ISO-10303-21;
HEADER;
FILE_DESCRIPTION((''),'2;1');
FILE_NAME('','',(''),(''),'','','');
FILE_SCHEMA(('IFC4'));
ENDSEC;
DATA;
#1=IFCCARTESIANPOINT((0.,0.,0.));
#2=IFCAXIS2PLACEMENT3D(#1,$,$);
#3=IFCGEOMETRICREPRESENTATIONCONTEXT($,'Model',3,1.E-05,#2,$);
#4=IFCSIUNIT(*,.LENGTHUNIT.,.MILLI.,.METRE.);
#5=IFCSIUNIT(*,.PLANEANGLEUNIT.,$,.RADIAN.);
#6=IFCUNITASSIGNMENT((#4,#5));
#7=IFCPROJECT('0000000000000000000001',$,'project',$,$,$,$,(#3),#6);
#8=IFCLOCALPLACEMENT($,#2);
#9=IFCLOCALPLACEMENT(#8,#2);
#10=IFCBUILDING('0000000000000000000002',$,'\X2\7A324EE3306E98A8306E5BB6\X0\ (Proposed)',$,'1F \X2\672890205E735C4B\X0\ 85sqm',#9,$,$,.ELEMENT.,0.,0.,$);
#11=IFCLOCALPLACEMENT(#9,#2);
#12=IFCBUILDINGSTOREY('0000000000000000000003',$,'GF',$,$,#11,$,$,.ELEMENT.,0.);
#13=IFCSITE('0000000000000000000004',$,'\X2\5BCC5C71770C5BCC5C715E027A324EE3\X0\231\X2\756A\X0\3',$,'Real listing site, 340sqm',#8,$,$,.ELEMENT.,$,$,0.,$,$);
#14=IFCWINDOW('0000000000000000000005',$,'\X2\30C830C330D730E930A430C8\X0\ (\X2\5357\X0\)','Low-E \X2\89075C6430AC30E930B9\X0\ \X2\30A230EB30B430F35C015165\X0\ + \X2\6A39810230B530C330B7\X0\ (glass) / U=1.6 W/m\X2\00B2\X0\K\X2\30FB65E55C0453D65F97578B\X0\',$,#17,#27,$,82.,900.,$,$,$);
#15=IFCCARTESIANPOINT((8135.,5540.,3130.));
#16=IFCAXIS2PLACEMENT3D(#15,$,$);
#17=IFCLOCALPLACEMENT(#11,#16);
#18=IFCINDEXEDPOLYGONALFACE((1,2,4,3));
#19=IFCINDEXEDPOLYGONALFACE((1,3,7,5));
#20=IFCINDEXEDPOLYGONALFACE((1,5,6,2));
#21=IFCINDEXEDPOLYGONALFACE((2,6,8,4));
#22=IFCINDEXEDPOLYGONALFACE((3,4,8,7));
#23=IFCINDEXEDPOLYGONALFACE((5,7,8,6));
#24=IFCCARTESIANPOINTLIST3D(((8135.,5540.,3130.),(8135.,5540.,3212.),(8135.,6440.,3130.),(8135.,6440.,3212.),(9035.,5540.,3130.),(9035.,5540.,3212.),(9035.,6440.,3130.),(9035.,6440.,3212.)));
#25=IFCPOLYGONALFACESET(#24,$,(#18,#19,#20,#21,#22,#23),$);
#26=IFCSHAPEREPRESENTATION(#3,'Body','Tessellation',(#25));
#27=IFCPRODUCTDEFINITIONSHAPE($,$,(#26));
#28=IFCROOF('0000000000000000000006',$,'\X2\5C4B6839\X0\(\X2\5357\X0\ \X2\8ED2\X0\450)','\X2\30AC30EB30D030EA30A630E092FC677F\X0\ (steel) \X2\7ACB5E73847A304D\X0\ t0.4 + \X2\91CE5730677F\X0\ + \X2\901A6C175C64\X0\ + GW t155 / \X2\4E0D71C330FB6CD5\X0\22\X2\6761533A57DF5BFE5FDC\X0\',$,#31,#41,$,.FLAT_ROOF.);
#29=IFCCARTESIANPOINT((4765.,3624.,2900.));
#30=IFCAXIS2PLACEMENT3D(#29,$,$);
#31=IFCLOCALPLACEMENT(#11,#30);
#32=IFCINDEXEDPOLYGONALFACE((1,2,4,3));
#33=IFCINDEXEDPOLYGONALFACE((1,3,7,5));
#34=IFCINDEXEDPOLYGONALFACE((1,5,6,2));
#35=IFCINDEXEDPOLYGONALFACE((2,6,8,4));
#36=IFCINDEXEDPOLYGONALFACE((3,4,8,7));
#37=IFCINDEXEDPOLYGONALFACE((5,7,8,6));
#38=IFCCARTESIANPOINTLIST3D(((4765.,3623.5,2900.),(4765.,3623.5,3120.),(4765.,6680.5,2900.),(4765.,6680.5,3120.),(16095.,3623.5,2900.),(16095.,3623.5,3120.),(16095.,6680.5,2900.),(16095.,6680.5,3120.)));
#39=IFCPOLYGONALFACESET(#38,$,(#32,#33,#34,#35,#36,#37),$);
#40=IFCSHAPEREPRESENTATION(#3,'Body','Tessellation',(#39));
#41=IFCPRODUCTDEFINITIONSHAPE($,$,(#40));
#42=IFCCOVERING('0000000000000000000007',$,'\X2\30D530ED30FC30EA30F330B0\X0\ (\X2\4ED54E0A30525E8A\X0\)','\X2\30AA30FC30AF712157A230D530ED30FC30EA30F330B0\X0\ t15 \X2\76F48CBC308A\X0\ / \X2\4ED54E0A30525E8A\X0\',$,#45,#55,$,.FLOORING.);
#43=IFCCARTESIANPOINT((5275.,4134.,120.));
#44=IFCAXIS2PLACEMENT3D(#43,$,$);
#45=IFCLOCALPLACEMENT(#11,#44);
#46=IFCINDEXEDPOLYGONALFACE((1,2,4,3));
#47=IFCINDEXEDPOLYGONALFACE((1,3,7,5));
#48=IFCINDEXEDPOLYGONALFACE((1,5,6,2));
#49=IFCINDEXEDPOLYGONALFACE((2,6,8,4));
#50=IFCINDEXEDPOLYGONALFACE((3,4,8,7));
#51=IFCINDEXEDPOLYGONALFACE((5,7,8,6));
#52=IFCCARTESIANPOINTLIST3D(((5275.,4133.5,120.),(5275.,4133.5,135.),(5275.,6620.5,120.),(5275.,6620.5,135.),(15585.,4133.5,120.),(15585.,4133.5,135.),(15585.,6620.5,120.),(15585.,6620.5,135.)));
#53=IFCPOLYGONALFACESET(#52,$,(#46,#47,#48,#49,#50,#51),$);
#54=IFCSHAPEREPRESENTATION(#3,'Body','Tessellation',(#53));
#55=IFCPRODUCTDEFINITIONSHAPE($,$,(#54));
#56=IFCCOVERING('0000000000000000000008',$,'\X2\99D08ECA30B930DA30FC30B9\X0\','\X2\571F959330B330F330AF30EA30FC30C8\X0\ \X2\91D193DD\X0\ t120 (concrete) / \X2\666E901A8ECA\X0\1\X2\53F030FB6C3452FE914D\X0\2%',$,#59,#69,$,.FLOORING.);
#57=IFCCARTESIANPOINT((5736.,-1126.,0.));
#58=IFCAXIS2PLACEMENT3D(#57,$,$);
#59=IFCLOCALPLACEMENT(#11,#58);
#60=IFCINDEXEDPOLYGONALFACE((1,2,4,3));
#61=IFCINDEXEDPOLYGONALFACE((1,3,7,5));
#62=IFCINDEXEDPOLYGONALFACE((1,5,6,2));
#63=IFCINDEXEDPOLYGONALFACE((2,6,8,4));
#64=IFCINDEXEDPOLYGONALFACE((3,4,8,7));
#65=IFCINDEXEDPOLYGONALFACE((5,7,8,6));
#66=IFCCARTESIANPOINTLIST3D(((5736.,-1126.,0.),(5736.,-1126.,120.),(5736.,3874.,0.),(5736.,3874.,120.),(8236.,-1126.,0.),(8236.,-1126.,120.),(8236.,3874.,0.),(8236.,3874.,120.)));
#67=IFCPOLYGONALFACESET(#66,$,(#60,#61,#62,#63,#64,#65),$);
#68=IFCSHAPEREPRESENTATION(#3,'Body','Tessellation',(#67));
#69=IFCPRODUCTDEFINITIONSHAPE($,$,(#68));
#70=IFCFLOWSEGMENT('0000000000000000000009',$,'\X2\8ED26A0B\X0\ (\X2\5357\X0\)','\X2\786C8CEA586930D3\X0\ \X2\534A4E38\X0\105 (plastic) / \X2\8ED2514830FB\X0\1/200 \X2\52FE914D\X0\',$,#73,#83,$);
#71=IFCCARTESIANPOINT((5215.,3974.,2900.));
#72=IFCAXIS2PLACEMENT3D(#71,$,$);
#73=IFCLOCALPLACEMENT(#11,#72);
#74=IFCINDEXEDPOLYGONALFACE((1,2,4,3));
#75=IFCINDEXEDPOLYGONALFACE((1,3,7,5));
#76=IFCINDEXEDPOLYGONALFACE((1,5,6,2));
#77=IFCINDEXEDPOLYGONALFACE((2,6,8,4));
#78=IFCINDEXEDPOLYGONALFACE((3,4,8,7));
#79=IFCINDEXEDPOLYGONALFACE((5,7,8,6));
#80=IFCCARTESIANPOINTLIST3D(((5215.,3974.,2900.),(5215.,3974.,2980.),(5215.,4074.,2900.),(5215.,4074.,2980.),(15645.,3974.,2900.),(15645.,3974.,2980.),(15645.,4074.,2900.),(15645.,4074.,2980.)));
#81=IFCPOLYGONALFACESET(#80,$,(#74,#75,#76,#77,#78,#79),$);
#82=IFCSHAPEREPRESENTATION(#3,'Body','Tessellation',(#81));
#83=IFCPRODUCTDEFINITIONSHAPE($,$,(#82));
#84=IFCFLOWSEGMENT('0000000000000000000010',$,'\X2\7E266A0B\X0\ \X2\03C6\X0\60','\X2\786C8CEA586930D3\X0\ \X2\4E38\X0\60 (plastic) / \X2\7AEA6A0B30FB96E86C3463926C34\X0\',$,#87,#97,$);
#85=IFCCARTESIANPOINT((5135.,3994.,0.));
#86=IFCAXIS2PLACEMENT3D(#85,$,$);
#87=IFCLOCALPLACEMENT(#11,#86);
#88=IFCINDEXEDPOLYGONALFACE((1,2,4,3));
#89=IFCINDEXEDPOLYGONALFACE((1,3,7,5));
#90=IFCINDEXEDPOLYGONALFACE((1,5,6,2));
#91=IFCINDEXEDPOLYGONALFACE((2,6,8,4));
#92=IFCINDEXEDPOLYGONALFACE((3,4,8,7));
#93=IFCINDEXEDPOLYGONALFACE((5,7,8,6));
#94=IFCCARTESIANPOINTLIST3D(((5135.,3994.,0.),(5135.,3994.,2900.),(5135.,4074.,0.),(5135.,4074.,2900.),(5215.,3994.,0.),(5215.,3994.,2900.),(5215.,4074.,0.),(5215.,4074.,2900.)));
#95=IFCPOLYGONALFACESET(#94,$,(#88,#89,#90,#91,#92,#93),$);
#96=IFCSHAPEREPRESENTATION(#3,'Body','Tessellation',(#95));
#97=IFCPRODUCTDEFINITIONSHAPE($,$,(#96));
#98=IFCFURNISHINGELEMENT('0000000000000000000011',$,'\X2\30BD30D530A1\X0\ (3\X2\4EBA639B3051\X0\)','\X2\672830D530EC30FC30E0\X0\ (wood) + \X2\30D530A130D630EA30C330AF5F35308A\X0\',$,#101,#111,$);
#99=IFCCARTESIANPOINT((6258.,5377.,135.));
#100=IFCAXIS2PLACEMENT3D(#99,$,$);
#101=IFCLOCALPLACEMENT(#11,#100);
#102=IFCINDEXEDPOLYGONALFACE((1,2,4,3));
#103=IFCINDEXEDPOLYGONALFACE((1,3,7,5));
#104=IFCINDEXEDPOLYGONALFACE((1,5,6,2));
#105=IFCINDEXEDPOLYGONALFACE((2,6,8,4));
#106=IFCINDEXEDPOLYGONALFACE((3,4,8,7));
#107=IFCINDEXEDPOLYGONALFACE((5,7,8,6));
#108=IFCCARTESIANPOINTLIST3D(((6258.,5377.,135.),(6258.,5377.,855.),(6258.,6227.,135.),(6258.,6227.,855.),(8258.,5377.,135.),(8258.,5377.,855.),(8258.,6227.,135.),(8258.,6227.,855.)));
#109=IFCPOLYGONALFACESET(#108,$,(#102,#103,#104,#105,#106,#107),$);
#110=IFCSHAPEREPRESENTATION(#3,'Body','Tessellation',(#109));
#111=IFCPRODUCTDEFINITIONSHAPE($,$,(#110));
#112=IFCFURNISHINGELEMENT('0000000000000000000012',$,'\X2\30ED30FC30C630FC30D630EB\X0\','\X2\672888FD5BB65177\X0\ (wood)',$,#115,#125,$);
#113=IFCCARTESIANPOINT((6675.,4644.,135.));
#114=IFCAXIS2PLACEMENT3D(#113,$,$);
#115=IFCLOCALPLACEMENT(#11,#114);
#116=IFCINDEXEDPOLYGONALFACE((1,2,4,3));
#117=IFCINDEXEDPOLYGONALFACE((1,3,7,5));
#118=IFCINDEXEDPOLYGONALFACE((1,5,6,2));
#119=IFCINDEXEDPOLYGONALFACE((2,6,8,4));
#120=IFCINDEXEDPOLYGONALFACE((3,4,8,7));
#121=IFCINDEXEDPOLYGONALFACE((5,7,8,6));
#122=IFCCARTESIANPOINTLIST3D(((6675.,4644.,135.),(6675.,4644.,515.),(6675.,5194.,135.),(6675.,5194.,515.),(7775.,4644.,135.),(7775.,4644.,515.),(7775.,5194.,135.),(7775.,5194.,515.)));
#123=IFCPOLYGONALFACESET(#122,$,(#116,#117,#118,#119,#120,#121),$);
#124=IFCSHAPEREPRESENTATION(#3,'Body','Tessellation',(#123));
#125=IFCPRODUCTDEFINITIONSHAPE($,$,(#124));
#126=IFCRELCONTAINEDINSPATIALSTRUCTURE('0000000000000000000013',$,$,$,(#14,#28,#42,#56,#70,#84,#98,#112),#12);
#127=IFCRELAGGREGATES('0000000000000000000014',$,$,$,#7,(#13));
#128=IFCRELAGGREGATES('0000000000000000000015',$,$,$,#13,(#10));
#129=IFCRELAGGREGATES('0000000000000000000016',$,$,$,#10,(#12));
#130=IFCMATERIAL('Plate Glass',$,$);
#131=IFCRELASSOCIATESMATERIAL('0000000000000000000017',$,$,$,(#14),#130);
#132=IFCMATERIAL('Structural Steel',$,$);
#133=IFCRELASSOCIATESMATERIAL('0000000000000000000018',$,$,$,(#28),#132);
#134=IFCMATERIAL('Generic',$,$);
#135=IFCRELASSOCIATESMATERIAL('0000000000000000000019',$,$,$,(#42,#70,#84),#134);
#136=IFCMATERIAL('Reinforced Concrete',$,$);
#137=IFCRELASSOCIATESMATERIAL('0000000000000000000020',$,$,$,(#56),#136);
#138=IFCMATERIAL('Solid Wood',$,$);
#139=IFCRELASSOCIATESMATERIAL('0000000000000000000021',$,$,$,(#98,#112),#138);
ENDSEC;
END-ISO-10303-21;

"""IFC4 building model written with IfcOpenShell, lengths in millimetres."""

from ifc_helpers import new_model, si_unit, frame, frame_2d, origin, place, context, project, spatial, rectangle, extrude, material, element, save


model = new_model("IFC4")

# Units and contexts
model_context = context("Model", 3, precision=1e-05, world=origin())
ifc_project = project(units=[si_unit("LENGTHUNIT", "METRE", prefix="MILLI"), si_unit("PLANEANGLEUNIT", "RADIAN")], contexts=[model_context])

# Site, building, storey
site_placement = place(None, origin())
site = spatial("IfcSite", under=ifc_project, at=site_placement, Name="富山県富山市稲代231番3", ObjectType="Real listing site, 340sqm", CompositionType="ELEMENT", RefElevation=0.0)
building_placement = place(site_placement, origin())
building = spatial("IfcBuilding", under=site, at=building_placement, Name="稲代の風の家 (Proposed)", ObjectType="1F 木造平屋 85sqm", CompositionType="ELEMENT", ElevationOfRefHeight=0.0, ElevationOfTerrain=0.0)
storey_placement = place(building_placement, origin())
storey = spatial("IfcBuildingStorey", under=building, at=storey_placement, Name="GF", CompositionType="ELEMENT", Elevation=0.0)

# Shared definitions
ifc_material_1 = material(Name="Solid Wood")

# Shared definitions
ifc_material_2 = material(Name="Reinforced Concrete")

# Shared definitions
ifc_material_3 = material(Name="Plate Glass")

# Window
window_1_placement = place(storey_placement, frame((8135.0, 5540.0, 3130.0)))
element("IfcWindow", 1, at=window_1_placement, inside=storey, material=ifc_material_3, Name="トップライト (南)", Description="Low-E 複層ガラス アルゴン封入 + 樹脂サッシ (glass) / U=1.6 W/m²K・日射取得型", OverallHeight=82.0, OverallWidth=900.0, context=model_context, shape_type="SweptSolid", body=[
    extrude(rectangle(XDim=900.0, YDim=900.0, at=frame_2d((450.0, 450.0))), frame((8135.0, 5540.0, 3130.0)), (0.0, 0.0, 1.0), 82.0),
])

# Roof
ifc_material_4 = material(Name="Structural Steel")
roof_1_placement = place(storey_placement, frame((4765.0, 3624.0, 2900.0)))
element("IfcRoof", 2, at=roof_1_placement, inside=storey, material=ifc_material_4, Name="屋根(南 軒450)", Description="ガルバリウム鋼板 (steel) 立平葺き t0.4 + 野地板 + 通気層 + GW t155 / 不燃・法22条区域対応", PredefinedType="FLAT_ROOF", context=model_context, shape_type="SweptSolid", body=[
    extrude(rectangle(XDim=11330.0, YDim=3057.0, at=frame_2d((5665.0, 1528.0))), frame((4765.0, 3624.0, 2900.0)), (0.0, 0.0, 1.0), 220.0),
])

# Coverings
ifc_material_5 = material(Name="Generic")
covering_1_placement = place(storey_placement, frame((5275.0, 4134.0, 120.0)))
element("IfcCovering", 3, at=covering_1_placement, inside=storey, material=ifc_material_5, Name="フローリング (仕上げ床)", Description="オーク無垢フローリング t15 直貼り / 仕上げ床", PredefinedType="FLOORING", context=model_context, shape_type="SweptSolid", body=[
    extrude(rectangle(XDim=10310.0, YDim=2487.0, at=frame_2d((5155.0, 1243.0))), frame((5275.0, 4134.0, 120.0)), (0.0, 0.0, 1.0), 15.0),
])
covering_2_placement = place(storey_placement, frame((5736.0, -1126.0, 0.0)))
element("IfcCovering", 4, at=covering_2_placement, inside=storey, material=ifc_material_2, Name="駐車スペース", Description="土間コンクリート 金鏝 t120 (concrete) / 普通車1台・水勾配2%", PredefinedType="FLOORING", context=model_context, shape_type="SweptSolid", body=[
    extrude(rectangle(XDim=2500.0, YDim=5000.0, at=frame_2d((1250.0, 2500.0))), frame((5736.0, -1126.0, 0.0)), (0.0, 0.0, 1.0), 120.0),
])

# Flow segments
flow_segment_1_placement = place(storey_placement, frame((5215.0, 3974.0, 2900.0)))
element("IfcFlowSegment", 5, at=flow_segment_1_placement, inside=storey, material=ifc_material_5, Name="軒樋 (南)", Description="硬質塩ビ 半丸105 (plastic) / 軒先・1/200 勾配", context=model_context, shape_type="SweptSolid", body=[
    extrude(rectangle(XDim=10430.0, YDim=100.0, at=frame_2d((5215.0, 50.0))), frame((5215.0, 3974.0, 2900.0)), (0.0, 0.0, 1.0), 80.0),
])
flow_segment_2_placement = place(storey_placement, frame((5135.0, 3994.0, 0.0)))
element("IfcFlowSegment", 6, at=flow_segment_2_placement, inside=storey, material=ifc_material_5, Name="縦樋 φ60", Description="硬質塩ビ 丸60 (plastic) / 竪樋・雨水排水", context=model_context, shape_type="SweptSolid", body=[
    extrude(rectangle(XDim=80.0, YDim=80.0, at=frame_2d((40.0, 40.0))), frame((5135.0, 3994.0, 0.0)), (0.0, 0.0, 1.0), 2900.0),
])

# Furnishing elements
furnishing_1_placement = place(storey_placement, frame((6258.0, 5377.0, 135.0)))
element("IfcFurnishingElement", 7, at=furnishing_1_placement, inside=storey, material=ifc_material_1, Name="ソファ (3人掛け)", Description="木フレーム (wood) + ファブリック張り", context=model_context, shape_type="SweptSolid", body=[
    extrude(rectangle(XDim=2000.0, YDim=850.0, at=frame_2d((1000.0, 425.0))), frame((6258.0, 5377.0, 135.0)), (0.0, 0.0, 1.0), 720.0),
])
furnishing_2_placement = place(storey_placement, frame((6675.0, 4644.0, 135.0)))
element("IfcFurnishingElement", 8, at=furnishing_2_placement, inside=storey, material=ifc_material_1, Name="ローテーブル", Description="木製家具 (wood)", context=model_context, shape_type="SweptSolid", body=[
    extrude(rectangle(XDim=1100.0, YDim=550.0, at=frame_2d((550.0, 275.0))), frame((6675.0, 4644.0, 135.0)), (0.0, 0.0, 1.0), 380.0),
])

save(model, "model.ifc")
